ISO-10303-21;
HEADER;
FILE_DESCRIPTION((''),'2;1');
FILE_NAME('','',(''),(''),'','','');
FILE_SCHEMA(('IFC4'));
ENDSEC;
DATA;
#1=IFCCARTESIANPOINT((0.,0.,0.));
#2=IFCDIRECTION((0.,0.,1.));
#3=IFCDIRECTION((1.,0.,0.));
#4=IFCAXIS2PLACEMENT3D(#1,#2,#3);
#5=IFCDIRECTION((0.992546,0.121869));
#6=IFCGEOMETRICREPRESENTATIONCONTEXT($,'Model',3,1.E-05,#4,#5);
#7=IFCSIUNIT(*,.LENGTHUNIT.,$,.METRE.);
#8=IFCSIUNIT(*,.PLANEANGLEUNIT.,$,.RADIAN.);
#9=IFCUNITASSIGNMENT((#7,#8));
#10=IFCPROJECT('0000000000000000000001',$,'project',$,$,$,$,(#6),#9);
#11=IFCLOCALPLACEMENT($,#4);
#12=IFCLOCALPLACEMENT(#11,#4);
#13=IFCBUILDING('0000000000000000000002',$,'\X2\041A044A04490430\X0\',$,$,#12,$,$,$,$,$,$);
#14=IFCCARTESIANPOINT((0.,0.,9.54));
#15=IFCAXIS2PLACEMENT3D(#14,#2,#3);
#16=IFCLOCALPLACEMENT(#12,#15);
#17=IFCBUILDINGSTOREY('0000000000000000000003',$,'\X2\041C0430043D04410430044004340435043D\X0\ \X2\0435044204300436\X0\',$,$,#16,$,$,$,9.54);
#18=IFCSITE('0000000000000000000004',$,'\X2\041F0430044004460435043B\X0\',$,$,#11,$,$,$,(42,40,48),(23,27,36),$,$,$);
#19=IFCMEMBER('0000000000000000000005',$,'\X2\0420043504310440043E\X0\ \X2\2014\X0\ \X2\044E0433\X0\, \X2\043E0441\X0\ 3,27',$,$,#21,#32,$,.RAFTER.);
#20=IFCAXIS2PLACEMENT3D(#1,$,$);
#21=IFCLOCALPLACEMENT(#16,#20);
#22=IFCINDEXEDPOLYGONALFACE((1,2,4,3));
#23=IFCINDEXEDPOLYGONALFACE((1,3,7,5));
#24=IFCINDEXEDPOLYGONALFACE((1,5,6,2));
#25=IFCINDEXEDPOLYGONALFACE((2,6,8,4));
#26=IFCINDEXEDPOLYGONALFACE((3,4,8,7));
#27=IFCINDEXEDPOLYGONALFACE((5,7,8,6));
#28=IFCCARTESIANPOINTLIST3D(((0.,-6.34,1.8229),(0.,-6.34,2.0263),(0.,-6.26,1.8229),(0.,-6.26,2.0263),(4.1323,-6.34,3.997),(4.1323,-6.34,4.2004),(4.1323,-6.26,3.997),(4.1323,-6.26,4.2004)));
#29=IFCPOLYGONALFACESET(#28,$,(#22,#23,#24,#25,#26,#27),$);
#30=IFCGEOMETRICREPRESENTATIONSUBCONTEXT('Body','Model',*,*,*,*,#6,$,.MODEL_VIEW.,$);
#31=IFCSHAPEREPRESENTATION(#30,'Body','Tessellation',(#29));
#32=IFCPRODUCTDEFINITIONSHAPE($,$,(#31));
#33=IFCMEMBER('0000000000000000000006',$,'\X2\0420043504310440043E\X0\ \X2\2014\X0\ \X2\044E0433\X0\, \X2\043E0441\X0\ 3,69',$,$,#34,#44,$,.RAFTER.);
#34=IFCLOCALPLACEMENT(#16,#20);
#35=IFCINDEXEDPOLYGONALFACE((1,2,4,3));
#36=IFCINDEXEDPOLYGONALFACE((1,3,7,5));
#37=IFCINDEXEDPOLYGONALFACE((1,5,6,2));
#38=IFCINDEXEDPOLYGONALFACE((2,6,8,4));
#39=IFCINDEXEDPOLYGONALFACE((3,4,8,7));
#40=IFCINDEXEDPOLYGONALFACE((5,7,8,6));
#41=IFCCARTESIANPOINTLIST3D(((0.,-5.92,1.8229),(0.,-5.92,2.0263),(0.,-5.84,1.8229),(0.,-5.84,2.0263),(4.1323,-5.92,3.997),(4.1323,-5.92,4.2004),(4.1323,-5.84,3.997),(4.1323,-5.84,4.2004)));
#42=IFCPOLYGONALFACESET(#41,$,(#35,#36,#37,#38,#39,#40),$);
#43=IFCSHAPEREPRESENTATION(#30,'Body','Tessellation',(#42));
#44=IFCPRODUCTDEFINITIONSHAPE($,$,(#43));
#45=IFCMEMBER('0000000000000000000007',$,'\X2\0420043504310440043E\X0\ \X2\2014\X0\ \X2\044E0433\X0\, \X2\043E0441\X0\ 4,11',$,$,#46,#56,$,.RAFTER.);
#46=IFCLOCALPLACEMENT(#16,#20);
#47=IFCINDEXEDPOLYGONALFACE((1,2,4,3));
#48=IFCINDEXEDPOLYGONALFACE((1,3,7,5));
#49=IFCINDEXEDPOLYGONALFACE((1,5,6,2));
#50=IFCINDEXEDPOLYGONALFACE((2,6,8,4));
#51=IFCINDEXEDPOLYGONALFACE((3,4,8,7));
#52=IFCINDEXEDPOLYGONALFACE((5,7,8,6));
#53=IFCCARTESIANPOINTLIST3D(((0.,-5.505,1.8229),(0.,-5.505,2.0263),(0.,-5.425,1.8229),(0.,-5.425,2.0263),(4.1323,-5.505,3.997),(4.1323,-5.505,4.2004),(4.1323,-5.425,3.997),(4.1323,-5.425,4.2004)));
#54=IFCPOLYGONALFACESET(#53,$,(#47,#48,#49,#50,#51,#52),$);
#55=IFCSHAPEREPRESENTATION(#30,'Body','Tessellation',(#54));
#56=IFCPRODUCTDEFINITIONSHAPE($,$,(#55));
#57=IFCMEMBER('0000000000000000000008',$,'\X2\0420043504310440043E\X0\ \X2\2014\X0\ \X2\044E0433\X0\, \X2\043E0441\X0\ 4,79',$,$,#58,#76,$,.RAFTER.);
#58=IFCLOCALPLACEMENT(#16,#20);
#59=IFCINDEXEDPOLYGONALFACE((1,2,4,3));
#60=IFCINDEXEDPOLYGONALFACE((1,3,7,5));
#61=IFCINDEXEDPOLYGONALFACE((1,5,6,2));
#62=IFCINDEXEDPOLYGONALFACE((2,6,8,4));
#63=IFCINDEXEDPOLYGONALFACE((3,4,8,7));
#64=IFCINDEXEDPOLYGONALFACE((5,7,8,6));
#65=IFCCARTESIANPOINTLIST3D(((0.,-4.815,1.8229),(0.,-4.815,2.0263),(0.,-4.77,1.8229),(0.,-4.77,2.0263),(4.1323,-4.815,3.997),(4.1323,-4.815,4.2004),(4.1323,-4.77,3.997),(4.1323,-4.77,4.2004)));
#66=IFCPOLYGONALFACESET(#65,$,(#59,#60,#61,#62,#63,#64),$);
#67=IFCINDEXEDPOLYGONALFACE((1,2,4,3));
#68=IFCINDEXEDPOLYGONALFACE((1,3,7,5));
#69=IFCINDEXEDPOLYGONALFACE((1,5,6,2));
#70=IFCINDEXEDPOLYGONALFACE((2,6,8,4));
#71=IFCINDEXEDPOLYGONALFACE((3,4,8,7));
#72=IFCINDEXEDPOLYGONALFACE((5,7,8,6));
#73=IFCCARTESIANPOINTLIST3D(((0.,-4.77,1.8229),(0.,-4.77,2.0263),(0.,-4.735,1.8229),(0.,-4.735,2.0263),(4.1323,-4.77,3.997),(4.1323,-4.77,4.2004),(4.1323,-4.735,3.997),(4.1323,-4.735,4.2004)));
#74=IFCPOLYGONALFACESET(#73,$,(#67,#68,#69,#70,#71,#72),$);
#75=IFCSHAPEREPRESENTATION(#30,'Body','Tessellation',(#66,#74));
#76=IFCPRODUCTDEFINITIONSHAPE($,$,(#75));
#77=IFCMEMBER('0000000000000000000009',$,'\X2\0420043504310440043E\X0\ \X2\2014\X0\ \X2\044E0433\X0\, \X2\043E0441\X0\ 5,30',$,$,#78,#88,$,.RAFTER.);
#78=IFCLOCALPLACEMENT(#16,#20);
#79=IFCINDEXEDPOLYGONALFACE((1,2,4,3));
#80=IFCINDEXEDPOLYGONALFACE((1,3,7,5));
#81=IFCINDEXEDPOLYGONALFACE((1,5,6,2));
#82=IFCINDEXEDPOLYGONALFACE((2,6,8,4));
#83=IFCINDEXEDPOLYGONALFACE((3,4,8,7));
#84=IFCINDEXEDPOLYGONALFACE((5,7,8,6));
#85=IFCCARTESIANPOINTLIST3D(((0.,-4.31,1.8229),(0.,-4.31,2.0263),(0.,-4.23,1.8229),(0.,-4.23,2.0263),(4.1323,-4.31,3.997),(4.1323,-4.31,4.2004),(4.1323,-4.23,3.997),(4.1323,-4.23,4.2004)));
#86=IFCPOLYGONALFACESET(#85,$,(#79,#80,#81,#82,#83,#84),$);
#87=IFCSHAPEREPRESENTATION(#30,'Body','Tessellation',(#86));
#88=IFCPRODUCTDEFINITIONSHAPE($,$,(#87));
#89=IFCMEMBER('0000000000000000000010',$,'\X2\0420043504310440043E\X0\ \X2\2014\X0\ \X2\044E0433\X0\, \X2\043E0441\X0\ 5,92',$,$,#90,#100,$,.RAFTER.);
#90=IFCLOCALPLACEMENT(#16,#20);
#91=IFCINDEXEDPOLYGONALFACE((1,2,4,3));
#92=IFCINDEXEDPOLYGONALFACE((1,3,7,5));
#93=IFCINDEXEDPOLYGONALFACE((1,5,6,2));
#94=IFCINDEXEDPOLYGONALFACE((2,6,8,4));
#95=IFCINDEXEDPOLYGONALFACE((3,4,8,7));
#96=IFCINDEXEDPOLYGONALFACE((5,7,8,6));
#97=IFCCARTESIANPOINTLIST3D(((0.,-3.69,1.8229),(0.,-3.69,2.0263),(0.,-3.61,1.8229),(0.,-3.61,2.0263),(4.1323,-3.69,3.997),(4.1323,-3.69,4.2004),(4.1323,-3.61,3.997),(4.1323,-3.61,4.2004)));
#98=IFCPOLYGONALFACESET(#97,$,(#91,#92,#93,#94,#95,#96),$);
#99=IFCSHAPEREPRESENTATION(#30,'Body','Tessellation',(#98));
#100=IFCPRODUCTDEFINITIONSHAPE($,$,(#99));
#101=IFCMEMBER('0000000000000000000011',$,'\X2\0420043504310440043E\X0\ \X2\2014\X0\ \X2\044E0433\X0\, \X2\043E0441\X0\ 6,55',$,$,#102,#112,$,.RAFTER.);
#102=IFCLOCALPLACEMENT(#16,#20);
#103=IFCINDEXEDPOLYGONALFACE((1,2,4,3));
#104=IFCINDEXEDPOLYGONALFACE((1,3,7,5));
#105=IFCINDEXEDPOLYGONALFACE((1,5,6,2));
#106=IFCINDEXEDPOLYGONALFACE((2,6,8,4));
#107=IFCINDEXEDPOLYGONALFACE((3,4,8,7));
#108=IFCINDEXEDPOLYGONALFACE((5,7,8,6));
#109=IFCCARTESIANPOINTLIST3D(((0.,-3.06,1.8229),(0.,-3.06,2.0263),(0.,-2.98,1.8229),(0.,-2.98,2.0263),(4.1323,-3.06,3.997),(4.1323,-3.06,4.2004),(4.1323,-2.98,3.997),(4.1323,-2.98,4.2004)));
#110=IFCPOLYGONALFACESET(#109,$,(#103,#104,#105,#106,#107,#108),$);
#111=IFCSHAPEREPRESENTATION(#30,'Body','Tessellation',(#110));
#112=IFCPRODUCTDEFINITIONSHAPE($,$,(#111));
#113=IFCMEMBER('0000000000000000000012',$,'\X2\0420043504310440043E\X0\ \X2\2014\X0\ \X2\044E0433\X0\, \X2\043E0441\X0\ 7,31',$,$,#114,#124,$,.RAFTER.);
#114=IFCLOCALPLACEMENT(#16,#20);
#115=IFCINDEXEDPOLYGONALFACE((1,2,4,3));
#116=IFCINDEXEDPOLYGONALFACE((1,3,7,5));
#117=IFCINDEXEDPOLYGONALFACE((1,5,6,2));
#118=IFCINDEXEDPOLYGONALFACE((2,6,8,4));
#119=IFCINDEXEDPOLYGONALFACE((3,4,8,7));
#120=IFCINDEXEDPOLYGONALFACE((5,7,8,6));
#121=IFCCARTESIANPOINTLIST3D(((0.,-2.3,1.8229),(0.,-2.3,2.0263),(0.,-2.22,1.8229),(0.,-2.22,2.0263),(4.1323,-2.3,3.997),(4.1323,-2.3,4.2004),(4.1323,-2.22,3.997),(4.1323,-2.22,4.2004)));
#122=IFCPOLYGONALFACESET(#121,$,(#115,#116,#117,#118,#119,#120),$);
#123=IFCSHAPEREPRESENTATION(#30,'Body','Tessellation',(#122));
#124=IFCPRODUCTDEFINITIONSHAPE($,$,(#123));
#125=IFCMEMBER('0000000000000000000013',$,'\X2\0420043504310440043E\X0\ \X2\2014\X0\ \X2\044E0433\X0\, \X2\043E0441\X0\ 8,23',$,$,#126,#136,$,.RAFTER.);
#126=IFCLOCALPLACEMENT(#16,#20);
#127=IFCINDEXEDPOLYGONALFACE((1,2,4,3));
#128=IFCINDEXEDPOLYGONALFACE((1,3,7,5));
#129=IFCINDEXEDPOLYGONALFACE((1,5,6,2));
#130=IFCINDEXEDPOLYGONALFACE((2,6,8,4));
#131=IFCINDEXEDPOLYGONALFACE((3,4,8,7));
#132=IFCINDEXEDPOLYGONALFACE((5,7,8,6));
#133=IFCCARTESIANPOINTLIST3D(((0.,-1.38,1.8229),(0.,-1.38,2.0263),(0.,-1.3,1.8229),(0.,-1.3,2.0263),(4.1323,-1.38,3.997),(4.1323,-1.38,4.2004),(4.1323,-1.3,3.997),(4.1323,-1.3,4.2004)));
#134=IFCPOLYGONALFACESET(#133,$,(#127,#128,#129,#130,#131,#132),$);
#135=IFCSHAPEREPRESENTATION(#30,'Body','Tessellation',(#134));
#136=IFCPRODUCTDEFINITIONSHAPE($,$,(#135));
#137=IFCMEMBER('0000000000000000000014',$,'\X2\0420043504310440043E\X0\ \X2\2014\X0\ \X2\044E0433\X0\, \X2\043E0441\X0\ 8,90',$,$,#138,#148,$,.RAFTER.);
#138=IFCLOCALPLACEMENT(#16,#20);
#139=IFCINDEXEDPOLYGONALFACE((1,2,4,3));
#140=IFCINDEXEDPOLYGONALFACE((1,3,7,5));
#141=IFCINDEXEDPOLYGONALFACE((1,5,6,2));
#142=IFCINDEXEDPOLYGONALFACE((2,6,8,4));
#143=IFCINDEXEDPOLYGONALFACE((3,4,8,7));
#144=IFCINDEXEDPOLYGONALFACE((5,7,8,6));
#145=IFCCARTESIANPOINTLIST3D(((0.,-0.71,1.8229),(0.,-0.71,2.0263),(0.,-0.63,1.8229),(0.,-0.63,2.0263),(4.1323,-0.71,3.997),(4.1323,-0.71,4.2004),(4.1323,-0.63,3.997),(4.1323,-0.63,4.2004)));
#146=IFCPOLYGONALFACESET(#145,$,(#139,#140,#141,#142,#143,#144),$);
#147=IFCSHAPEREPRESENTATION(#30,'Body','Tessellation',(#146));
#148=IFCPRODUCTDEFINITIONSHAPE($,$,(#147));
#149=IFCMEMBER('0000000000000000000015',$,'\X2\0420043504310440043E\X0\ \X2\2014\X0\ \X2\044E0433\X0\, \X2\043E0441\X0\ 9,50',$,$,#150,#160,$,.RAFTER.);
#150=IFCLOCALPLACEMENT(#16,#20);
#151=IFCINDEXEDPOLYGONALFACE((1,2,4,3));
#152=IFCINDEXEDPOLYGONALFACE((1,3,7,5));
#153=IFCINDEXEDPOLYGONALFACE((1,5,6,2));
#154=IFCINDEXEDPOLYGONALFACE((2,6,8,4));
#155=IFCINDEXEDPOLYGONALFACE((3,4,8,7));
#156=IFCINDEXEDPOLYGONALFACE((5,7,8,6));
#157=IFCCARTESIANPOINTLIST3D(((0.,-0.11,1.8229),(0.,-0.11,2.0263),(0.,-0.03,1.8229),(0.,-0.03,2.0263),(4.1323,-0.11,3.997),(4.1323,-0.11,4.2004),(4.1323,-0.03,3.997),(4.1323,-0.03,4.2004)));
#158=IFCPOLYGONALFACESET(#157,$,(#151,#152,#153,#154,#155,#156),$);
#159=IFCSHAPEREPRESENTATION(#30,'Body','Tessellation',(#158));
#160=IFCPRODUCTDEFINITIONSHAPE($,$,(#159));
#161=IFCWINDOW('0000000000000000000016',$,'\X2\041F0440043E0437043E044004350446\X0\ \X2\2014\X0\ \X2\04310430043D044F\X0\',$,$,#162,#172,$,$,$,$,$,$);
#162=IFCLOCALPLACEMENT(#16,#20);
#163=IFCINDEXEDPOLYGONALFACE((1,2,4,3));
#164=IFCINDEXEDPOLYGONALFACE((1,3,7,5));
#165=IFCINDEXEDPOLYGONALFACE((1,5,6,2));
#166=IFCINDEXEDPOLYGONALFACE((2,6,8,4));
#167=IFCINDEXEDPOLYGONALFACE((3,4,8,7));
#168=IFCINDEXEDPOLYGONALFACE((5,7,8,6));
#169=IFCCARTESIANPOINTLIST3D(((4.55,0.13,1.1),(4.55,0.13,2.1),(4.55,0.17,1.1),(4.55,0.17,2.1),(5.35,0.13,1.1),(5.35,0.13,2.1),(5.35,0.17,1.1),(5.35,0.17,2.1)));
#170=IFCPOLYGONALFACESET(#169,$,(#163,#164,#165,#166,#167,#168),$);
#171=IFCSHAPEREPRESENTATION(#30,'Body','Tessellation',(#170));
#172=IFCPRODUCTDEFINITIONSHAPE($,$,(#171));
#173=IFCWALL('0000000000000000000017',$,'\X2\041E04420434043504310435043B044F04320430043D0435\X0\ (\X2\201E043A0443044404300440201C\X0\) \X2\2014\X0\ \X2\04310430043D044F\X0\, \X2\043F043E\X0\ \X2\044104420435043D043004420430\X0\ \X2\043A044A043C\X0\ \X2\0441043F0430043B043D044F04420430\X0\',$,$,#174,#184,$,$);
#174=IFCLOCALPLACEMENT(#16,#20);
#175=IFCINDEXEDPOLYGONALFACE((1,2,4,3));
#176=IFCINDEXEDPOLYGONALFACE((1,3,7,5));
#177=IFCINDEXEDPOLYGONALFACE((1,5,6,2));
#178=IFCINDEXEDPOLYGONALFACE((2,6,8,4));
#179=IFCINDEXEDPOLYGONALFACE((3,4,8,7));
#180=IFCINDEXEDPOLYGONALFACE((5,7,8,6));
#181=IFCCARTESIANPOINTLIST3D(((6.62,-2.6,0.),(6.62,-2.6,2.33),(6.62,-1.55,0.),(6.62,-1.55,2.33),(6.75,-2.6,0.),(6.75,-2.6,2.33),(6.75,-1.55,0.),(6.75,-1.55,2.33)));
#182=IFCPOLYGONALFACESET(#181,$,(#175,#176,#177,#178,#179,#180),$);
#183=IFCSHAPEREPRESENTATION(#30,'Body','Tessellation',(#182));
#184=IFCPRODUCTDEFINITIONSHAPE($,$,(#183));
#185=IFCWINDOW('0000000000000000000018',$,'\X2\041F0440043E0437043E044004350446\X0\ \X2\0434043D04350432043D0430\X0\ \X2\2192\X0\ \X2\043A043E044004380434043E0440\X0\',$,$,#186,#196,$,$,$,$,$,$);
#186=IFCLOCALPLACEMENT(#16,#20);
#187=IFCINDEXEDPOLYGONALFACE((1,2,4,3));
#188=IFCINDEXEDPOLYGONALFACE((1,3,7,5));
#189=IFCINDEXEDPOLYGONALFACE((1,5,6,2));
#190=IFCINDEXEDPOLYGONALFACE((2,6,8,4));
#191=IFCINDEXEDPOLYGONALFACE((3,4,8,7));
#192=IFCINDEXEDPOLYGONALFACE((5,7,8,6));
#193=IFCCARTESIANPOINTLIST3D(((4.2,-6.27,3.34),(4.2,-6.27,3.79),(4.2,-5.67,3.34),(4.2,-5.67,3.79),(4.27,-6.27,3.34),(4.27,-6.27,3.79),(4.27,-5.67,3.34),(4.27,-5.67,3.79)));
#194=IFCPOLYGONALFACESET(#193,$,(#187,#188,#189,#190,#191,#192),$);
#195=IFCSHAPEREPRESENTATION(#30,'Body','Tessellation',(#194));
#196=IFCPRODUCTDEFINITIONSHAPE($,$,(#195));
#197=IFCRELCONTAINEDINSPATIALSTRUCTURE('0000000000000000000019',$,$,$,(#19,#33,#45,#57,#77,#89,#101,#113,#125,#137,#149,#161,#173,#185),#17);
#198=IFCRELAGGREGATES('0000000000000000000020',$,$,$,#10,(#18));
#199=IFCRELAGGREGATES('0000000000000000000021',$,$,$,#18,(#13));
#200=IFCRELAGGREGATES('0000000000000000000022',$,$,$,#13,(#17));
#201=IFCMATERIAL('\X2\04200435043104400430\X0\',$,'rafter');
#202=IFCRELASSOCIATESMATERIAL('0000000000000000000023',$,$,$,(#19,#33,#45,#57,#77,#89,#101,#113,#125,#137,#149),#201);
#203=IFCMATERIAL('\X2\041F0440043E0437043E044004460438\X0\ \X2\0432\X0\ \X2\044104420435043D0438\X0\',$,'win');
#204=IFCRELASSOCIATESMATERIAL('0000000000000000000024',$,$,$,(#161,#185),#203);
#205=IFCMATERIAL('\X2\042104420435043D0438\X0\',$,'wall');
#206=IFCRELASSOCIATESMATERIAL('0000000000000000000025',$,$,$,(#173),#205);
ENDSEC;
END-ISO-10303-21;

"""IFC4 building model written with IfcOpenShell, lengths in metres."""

from ifc_helpers import new_model, si_unit, direction, frame, origin_with_axes, place, context, subcontext, project, spatial, polyline, outline, extrude, material, element, save


model = new_model("IFC4")

# Units and contexts
model_context = context("Model", 3, precision=1e-05, world=origin_with_axes(), true_north=direction((0.992546, 0.121869)))
body_context = subcontext(model_context, "Body", "Model", "MODEL_VIEW")
ifc_project = project(units=[si_unit("LENGTHUNIT", "METRE"), si_unit("PLANEANGLEUNIT", "RADIAN")], contexts=[model_context])

# Site, building, storey
site_placement = place(None, origin_with_axes())
site = spatial("IfcSite", under=ifc_project, at=site_placement, Name="Парцел", RefLatitude=(42, 40, 48), RefLongitude=(23, 27, 36))
building_placement = place(site_placement, origin_with_axes())
building = spatial("IfcBuilding", under=site, at=building_placement, Name="Къща")
storey_placement = place(building_placement, frame((0.0, 0.0, 9.54), z_axis=(0.0, 0.0, 1.0), x_axis=(1.0, 0.0, 0.0)))
storey = spatial("IfcBuildingStorey", under=building, at=storey_placement, Name="Мансарден етаж", Elevation=9.54)

# Members
ifc_material_1 = material(Name="Ребра", Category="rafter")
member_1_placement = place(storey_placement, origin_with_axes())
element("IfcMember", 1, at=member_1_placement, inside=storey, material=ifc_material_1, Name="Ребро — юг, ос 3,27", PredefinedType="RAFTER", context=body_context, shape_type="SweptSolid", body=[
    extrude(outline(polyline([(0.0, -1.8229), (4.1323, -3.997), (4.1323, -4.2004), (0.0, -2.0263), (0.0, -1.8229)])), frame((0.0, -6.34, 0.0), z_axis=(0.0, 1.0, 0.0), x_axis=(1.0, 0.0, 0.0)), (0.0, 0.0, 1.0), 0.08),
])
member_2_placement = place(storey_placement, origin_with_axes())
element("IfcMember", 2, at=member_2_placement, inside=storey, material=ifc_material_1, Name="Ребро — юг, ос 3,69", PredefinedType="RAFTER", context=body_context, shape_type="SweptSolid", body=[
    extrude(outline(polyline([(0.0, -1.8229), (4.1323, -3.997), (4.1323, -4.2004), (0.0, -2.0263), (0.0, -1.8229)])), frame((0.0, -5.92, 0.0), z_axis=(0.0, 1.0, 0.0), x_axis=(1.0, 0.0, 0.0)), (0.0, 0.0, 1.0), 0.08),
])
member_3_placement = place(storey_placement, origin_with_axes())
element("IfcMember", 3, at=member_3_placement, inside=storey, material=ifc_material_1, Name="Ребро — юг, ос 4,11", PredefinedType="RAFTER", context=body_context, shape_type="SweptSolid", body=[
    extrude(outline(polyline([(0.0, -1.8229), (4.1323, -3.997), (4.1323, -4.2004), (0.0, -2.0263), (0.0, -1.8229)])), frame((0.0, -5.505, 0.0), z_axis=(0.0, 1.0, 0.0), x_axis=(1.0, 0.0, 0.0)), (0.0, 0.0, 1.0), 0.08),
])
member_4_placement = place(storey_placement, origin_with_axes())
element("IfcMember", 4, at=member_4_placement, inside=storey, material=ifc_material_1, Name="Ребро — юг, ос 4,79", PredefinedType="RAFTER", context=body_context, shape_type="SweptSolid", body=[
    extrude(outline(polyline([(0.0, -1.8229), (4.1323, -3.997), (4.1323, -4.2004), (0.0, -2.0263), (0.0, -1.8229)])), frame((0.0, -4.815, 0.0), z_axis=(0.0, 1.0, 0.0), x_axis=(1.0, 0.0, 0.0)), (0.0, 0.0, 1.0), 0.045),
    extrude(outline(polyline([(0.0, -1.8229), (4.1323, -3.997), (4.1323, -4.2004), (0.0, -2.0263), (0.0, -1.8229)])), frame((0.0, -4.77, 0.0), z_axis=(0.0, 1.0, 0.0), x_axis=(1.0, 0.0, 0.0)), (0.0, 0.0, 1.0), 0.035),
])
member_5_placement = place(storey_placement, origin_with_axes())
element("IfcMember", 5, at=member_5_placement, inside=storey, material=ifc_material_1, Name="Ребро — юг, ос 5,30", PredefinedType="RAFTER", context=body_context, shape_type="SweptSolid", body=[
    extrude(outline(polyline([(0.0, -1.8229), (4.1323, -3.997), (4.1323, -4.2004), (0.0, -2.0263), (0.0, -1.8229)])), frame((0.0, -4.31, 0.0), z_axis=(0.0, 1.0, 0.0), x_axis=(1.0, 0.0, 0.0)), (0.0, 0.0, 1.0), 0.08),
])
member_6_placement = place(storey_placement, origin_with_axes())
element("IfcMember", 6, at=member_6_placement, inside=storey, material=ifc_material_1, Name="Ребро — юг, ос 5,92", PredefinedType="RAFTER", context=body_context, shape_type="SweptSolid", body=[
    extrude(outline(polyline([(0.0, -1.8229), (4.1323, -3.997), (4.1323, -4.2004), (0.0, -2.0263), (0.0, -1.8229)])), frame((0.0, -3.69, 0.0), z_axis=(0.0, 1.0, 0.0), x_axis=(1.0, 0.0, 0.0)), (0.0, 0.0, 1.0), 0.08),
])
member_7_placement = place(storey_placement, origin_with_axes())
element("IfcMember", 7, at=member_7_placement, inside=storey, material=ifc_material_1, Name="Ребро — юг, ос 6,55", PredefinedType="RAFTER", context=body_context, shape_type="SweptSolid", body=[
    extrude(outline(polyline([(0.0, -1.8229), (4.1323, -3.997), (4.1323, -4.2004), (0.0, -2.0263), (0.0, -1.8229)])), frame((0.0, -3.06, 0.0), z_axis=(0.0, 1.0, 0.0), x_axis=(1.0, 0.0, 0.0)), (0.0, 0.0, 1.0), 0.08),
])
member_8_placement = place(storey_placement, origin_with_axes())
element("IfcMember", 8, at=member_8_placement, inside=storey, material=ifc_material_1, Name="Ребро — юг, ос 7,31", PredefinedType="RAFTER", context=body_context, shape_type="SweptSolid", body=[
    extrude(outline(polyline([(0.0, -1.8229), (4.1323, -3.997), (4.1323, -4.2004), (0.0, -2.0263), (0.0, -1.8229)])), frame((0.0, -2.3, 0.0), z_axis=(0.0, 1.0, 0.0), x_axis=(1.0, 0.0, 0.0)), (0.0, 0.0, 1.0), 0.08),
])
member_9_placement = place(storey_placement, origin_with_axes())
element("IfcMember", 9, at=member_9_placement, inside=storey, material=ifc_material_1, Name="Ребро — юг, ос 8,23", PredefinedType="RAFTER", context=body_context, shape_type="SweptSolid", body=[
    extrude(outline(polyline([(0.0, -1.8229), (4.1323, -3.997), (4.1323, -4.2004), (0.0, -2.0263), (0.0, -1.8229)])), frame((0.0, -1.38, 0.0), z_axis=(0.0, 1.0, 0.0), x_axis=(1.0, 0.0, 0.0)), (0.0, 0.0, 1.0), 0.08),
])
member_10_placement = place(storey_placement, origin_with_axes())
element("IfcMember", 10, at=member_10_placement, inside=storey, material=ifc_material_1, Name="Ребро — юг, ос 8,90", PredefinedType="RAFTER", context=body_context, shape_type="SweptSolid", body=[
    extrude(outline(polyline([(0.0, -1.8229), (4.1323, -3.997), (4.1323, -4.2004), (0.0, -2.0263), (0.0, -1.8229)])), frame((0.0, -0.71, 0.0), z_axis=(0.0, 1.0, 0.0), x_axis=(1.0, 0.0, 0.0)), (0.0, 0.0, 1.0), 0.08),
])
member_11_placement = place(storey_placement, origin_with_axes())
element("IfcMember", 11, at=member_11_placement, inside=storey, material=ifc_material_1, Name="Ребро — юг, ос 9,50", PredefinedType="RAFTER", context=body_context, shape_type="SweptSolid", body=[
    extrude(outline(polyline([(0.0, -1.8229), (4.1323, -3.997), (4.1323, -4.2004), (0.0, -2.0263), (0.0, -1.8229)])), frame((0.0, -0.11, 0.0), z_axis=(0.0, 1.0, 0.0), x_axis=(1.0, 0.0, 0.0)), (0.0, 0.0, 1.0), 0.08),
])

# Window
ifc_material_2 = material(Name="Прозорци в стени", Category="win")
window_1_placement = place(storey_placement, origin_with_axes())
element("IfcWindow", 12, at=window_1_placement, inside=storey, material=ifc_material_2, Name="Прозорец — баня", context=body_context, shape_type="SweptSolid", body=[
    extrude(outline(polyline([(4.55, -1.1), (5.35, -1.1), (5.35, -2.1), (4.55, -2.1), (4.55, -1.1)])), frame((0.0, 0.13, 0.0), z_axis=(0.0, 1.0, 0.0), x_axis=(1.0, 0.0, 0.0)), (0.0, 0.0, 1.0), 0.04),
])

# Wall
ifc_material_3 = material(Name="Стени", Category="wall")
wall_placement = place(storey_placement, origin_with_axes())
element("IfcWall", 13, at=wall_placement, inside=storey, material=ifc_material_3, Name="Отдебеляване („куфар“) — баня, по стената към спалнята", context=body_context, shape_type="SweptSolid", body=[
    extrude(outline(polyline([(6.62, 0.0), (6.75, 0.0), (6.75, -2.33), (6.62, -2.33), (6.62, 0.0)])), frame((0.0, -2.6, 0.0), z_axis=(0.0, 1.0, 0.0), x_axis=(1.0, 0.0, 0.0)), (0.0, 0.0, 1.0), 1.05),
])

# Window
window_2_placement = place(storey_placement, origin_with_axes())
element("IfcWindow", 14, at=window_2_placement, inside=storey, material=ifc_material_2, Name="Прозорец дневна → коридор", context=body_context, shape_type="SweptSolid", body=[
    extrude(outline(polyline([(4.2, -3.34), (4.27, -3.34), (4.27, -3.79), (4.2, -3.79), (4.2, -3.34)])), frame((0.0, -6.27, 0.0), z_axis=(0.0, 1.0, 0.0), x_axis=(1.0, 0.0, 0.0)), (0.0, 0.0, 1.0), 0.6),
])

save(model, "model.ifc")
